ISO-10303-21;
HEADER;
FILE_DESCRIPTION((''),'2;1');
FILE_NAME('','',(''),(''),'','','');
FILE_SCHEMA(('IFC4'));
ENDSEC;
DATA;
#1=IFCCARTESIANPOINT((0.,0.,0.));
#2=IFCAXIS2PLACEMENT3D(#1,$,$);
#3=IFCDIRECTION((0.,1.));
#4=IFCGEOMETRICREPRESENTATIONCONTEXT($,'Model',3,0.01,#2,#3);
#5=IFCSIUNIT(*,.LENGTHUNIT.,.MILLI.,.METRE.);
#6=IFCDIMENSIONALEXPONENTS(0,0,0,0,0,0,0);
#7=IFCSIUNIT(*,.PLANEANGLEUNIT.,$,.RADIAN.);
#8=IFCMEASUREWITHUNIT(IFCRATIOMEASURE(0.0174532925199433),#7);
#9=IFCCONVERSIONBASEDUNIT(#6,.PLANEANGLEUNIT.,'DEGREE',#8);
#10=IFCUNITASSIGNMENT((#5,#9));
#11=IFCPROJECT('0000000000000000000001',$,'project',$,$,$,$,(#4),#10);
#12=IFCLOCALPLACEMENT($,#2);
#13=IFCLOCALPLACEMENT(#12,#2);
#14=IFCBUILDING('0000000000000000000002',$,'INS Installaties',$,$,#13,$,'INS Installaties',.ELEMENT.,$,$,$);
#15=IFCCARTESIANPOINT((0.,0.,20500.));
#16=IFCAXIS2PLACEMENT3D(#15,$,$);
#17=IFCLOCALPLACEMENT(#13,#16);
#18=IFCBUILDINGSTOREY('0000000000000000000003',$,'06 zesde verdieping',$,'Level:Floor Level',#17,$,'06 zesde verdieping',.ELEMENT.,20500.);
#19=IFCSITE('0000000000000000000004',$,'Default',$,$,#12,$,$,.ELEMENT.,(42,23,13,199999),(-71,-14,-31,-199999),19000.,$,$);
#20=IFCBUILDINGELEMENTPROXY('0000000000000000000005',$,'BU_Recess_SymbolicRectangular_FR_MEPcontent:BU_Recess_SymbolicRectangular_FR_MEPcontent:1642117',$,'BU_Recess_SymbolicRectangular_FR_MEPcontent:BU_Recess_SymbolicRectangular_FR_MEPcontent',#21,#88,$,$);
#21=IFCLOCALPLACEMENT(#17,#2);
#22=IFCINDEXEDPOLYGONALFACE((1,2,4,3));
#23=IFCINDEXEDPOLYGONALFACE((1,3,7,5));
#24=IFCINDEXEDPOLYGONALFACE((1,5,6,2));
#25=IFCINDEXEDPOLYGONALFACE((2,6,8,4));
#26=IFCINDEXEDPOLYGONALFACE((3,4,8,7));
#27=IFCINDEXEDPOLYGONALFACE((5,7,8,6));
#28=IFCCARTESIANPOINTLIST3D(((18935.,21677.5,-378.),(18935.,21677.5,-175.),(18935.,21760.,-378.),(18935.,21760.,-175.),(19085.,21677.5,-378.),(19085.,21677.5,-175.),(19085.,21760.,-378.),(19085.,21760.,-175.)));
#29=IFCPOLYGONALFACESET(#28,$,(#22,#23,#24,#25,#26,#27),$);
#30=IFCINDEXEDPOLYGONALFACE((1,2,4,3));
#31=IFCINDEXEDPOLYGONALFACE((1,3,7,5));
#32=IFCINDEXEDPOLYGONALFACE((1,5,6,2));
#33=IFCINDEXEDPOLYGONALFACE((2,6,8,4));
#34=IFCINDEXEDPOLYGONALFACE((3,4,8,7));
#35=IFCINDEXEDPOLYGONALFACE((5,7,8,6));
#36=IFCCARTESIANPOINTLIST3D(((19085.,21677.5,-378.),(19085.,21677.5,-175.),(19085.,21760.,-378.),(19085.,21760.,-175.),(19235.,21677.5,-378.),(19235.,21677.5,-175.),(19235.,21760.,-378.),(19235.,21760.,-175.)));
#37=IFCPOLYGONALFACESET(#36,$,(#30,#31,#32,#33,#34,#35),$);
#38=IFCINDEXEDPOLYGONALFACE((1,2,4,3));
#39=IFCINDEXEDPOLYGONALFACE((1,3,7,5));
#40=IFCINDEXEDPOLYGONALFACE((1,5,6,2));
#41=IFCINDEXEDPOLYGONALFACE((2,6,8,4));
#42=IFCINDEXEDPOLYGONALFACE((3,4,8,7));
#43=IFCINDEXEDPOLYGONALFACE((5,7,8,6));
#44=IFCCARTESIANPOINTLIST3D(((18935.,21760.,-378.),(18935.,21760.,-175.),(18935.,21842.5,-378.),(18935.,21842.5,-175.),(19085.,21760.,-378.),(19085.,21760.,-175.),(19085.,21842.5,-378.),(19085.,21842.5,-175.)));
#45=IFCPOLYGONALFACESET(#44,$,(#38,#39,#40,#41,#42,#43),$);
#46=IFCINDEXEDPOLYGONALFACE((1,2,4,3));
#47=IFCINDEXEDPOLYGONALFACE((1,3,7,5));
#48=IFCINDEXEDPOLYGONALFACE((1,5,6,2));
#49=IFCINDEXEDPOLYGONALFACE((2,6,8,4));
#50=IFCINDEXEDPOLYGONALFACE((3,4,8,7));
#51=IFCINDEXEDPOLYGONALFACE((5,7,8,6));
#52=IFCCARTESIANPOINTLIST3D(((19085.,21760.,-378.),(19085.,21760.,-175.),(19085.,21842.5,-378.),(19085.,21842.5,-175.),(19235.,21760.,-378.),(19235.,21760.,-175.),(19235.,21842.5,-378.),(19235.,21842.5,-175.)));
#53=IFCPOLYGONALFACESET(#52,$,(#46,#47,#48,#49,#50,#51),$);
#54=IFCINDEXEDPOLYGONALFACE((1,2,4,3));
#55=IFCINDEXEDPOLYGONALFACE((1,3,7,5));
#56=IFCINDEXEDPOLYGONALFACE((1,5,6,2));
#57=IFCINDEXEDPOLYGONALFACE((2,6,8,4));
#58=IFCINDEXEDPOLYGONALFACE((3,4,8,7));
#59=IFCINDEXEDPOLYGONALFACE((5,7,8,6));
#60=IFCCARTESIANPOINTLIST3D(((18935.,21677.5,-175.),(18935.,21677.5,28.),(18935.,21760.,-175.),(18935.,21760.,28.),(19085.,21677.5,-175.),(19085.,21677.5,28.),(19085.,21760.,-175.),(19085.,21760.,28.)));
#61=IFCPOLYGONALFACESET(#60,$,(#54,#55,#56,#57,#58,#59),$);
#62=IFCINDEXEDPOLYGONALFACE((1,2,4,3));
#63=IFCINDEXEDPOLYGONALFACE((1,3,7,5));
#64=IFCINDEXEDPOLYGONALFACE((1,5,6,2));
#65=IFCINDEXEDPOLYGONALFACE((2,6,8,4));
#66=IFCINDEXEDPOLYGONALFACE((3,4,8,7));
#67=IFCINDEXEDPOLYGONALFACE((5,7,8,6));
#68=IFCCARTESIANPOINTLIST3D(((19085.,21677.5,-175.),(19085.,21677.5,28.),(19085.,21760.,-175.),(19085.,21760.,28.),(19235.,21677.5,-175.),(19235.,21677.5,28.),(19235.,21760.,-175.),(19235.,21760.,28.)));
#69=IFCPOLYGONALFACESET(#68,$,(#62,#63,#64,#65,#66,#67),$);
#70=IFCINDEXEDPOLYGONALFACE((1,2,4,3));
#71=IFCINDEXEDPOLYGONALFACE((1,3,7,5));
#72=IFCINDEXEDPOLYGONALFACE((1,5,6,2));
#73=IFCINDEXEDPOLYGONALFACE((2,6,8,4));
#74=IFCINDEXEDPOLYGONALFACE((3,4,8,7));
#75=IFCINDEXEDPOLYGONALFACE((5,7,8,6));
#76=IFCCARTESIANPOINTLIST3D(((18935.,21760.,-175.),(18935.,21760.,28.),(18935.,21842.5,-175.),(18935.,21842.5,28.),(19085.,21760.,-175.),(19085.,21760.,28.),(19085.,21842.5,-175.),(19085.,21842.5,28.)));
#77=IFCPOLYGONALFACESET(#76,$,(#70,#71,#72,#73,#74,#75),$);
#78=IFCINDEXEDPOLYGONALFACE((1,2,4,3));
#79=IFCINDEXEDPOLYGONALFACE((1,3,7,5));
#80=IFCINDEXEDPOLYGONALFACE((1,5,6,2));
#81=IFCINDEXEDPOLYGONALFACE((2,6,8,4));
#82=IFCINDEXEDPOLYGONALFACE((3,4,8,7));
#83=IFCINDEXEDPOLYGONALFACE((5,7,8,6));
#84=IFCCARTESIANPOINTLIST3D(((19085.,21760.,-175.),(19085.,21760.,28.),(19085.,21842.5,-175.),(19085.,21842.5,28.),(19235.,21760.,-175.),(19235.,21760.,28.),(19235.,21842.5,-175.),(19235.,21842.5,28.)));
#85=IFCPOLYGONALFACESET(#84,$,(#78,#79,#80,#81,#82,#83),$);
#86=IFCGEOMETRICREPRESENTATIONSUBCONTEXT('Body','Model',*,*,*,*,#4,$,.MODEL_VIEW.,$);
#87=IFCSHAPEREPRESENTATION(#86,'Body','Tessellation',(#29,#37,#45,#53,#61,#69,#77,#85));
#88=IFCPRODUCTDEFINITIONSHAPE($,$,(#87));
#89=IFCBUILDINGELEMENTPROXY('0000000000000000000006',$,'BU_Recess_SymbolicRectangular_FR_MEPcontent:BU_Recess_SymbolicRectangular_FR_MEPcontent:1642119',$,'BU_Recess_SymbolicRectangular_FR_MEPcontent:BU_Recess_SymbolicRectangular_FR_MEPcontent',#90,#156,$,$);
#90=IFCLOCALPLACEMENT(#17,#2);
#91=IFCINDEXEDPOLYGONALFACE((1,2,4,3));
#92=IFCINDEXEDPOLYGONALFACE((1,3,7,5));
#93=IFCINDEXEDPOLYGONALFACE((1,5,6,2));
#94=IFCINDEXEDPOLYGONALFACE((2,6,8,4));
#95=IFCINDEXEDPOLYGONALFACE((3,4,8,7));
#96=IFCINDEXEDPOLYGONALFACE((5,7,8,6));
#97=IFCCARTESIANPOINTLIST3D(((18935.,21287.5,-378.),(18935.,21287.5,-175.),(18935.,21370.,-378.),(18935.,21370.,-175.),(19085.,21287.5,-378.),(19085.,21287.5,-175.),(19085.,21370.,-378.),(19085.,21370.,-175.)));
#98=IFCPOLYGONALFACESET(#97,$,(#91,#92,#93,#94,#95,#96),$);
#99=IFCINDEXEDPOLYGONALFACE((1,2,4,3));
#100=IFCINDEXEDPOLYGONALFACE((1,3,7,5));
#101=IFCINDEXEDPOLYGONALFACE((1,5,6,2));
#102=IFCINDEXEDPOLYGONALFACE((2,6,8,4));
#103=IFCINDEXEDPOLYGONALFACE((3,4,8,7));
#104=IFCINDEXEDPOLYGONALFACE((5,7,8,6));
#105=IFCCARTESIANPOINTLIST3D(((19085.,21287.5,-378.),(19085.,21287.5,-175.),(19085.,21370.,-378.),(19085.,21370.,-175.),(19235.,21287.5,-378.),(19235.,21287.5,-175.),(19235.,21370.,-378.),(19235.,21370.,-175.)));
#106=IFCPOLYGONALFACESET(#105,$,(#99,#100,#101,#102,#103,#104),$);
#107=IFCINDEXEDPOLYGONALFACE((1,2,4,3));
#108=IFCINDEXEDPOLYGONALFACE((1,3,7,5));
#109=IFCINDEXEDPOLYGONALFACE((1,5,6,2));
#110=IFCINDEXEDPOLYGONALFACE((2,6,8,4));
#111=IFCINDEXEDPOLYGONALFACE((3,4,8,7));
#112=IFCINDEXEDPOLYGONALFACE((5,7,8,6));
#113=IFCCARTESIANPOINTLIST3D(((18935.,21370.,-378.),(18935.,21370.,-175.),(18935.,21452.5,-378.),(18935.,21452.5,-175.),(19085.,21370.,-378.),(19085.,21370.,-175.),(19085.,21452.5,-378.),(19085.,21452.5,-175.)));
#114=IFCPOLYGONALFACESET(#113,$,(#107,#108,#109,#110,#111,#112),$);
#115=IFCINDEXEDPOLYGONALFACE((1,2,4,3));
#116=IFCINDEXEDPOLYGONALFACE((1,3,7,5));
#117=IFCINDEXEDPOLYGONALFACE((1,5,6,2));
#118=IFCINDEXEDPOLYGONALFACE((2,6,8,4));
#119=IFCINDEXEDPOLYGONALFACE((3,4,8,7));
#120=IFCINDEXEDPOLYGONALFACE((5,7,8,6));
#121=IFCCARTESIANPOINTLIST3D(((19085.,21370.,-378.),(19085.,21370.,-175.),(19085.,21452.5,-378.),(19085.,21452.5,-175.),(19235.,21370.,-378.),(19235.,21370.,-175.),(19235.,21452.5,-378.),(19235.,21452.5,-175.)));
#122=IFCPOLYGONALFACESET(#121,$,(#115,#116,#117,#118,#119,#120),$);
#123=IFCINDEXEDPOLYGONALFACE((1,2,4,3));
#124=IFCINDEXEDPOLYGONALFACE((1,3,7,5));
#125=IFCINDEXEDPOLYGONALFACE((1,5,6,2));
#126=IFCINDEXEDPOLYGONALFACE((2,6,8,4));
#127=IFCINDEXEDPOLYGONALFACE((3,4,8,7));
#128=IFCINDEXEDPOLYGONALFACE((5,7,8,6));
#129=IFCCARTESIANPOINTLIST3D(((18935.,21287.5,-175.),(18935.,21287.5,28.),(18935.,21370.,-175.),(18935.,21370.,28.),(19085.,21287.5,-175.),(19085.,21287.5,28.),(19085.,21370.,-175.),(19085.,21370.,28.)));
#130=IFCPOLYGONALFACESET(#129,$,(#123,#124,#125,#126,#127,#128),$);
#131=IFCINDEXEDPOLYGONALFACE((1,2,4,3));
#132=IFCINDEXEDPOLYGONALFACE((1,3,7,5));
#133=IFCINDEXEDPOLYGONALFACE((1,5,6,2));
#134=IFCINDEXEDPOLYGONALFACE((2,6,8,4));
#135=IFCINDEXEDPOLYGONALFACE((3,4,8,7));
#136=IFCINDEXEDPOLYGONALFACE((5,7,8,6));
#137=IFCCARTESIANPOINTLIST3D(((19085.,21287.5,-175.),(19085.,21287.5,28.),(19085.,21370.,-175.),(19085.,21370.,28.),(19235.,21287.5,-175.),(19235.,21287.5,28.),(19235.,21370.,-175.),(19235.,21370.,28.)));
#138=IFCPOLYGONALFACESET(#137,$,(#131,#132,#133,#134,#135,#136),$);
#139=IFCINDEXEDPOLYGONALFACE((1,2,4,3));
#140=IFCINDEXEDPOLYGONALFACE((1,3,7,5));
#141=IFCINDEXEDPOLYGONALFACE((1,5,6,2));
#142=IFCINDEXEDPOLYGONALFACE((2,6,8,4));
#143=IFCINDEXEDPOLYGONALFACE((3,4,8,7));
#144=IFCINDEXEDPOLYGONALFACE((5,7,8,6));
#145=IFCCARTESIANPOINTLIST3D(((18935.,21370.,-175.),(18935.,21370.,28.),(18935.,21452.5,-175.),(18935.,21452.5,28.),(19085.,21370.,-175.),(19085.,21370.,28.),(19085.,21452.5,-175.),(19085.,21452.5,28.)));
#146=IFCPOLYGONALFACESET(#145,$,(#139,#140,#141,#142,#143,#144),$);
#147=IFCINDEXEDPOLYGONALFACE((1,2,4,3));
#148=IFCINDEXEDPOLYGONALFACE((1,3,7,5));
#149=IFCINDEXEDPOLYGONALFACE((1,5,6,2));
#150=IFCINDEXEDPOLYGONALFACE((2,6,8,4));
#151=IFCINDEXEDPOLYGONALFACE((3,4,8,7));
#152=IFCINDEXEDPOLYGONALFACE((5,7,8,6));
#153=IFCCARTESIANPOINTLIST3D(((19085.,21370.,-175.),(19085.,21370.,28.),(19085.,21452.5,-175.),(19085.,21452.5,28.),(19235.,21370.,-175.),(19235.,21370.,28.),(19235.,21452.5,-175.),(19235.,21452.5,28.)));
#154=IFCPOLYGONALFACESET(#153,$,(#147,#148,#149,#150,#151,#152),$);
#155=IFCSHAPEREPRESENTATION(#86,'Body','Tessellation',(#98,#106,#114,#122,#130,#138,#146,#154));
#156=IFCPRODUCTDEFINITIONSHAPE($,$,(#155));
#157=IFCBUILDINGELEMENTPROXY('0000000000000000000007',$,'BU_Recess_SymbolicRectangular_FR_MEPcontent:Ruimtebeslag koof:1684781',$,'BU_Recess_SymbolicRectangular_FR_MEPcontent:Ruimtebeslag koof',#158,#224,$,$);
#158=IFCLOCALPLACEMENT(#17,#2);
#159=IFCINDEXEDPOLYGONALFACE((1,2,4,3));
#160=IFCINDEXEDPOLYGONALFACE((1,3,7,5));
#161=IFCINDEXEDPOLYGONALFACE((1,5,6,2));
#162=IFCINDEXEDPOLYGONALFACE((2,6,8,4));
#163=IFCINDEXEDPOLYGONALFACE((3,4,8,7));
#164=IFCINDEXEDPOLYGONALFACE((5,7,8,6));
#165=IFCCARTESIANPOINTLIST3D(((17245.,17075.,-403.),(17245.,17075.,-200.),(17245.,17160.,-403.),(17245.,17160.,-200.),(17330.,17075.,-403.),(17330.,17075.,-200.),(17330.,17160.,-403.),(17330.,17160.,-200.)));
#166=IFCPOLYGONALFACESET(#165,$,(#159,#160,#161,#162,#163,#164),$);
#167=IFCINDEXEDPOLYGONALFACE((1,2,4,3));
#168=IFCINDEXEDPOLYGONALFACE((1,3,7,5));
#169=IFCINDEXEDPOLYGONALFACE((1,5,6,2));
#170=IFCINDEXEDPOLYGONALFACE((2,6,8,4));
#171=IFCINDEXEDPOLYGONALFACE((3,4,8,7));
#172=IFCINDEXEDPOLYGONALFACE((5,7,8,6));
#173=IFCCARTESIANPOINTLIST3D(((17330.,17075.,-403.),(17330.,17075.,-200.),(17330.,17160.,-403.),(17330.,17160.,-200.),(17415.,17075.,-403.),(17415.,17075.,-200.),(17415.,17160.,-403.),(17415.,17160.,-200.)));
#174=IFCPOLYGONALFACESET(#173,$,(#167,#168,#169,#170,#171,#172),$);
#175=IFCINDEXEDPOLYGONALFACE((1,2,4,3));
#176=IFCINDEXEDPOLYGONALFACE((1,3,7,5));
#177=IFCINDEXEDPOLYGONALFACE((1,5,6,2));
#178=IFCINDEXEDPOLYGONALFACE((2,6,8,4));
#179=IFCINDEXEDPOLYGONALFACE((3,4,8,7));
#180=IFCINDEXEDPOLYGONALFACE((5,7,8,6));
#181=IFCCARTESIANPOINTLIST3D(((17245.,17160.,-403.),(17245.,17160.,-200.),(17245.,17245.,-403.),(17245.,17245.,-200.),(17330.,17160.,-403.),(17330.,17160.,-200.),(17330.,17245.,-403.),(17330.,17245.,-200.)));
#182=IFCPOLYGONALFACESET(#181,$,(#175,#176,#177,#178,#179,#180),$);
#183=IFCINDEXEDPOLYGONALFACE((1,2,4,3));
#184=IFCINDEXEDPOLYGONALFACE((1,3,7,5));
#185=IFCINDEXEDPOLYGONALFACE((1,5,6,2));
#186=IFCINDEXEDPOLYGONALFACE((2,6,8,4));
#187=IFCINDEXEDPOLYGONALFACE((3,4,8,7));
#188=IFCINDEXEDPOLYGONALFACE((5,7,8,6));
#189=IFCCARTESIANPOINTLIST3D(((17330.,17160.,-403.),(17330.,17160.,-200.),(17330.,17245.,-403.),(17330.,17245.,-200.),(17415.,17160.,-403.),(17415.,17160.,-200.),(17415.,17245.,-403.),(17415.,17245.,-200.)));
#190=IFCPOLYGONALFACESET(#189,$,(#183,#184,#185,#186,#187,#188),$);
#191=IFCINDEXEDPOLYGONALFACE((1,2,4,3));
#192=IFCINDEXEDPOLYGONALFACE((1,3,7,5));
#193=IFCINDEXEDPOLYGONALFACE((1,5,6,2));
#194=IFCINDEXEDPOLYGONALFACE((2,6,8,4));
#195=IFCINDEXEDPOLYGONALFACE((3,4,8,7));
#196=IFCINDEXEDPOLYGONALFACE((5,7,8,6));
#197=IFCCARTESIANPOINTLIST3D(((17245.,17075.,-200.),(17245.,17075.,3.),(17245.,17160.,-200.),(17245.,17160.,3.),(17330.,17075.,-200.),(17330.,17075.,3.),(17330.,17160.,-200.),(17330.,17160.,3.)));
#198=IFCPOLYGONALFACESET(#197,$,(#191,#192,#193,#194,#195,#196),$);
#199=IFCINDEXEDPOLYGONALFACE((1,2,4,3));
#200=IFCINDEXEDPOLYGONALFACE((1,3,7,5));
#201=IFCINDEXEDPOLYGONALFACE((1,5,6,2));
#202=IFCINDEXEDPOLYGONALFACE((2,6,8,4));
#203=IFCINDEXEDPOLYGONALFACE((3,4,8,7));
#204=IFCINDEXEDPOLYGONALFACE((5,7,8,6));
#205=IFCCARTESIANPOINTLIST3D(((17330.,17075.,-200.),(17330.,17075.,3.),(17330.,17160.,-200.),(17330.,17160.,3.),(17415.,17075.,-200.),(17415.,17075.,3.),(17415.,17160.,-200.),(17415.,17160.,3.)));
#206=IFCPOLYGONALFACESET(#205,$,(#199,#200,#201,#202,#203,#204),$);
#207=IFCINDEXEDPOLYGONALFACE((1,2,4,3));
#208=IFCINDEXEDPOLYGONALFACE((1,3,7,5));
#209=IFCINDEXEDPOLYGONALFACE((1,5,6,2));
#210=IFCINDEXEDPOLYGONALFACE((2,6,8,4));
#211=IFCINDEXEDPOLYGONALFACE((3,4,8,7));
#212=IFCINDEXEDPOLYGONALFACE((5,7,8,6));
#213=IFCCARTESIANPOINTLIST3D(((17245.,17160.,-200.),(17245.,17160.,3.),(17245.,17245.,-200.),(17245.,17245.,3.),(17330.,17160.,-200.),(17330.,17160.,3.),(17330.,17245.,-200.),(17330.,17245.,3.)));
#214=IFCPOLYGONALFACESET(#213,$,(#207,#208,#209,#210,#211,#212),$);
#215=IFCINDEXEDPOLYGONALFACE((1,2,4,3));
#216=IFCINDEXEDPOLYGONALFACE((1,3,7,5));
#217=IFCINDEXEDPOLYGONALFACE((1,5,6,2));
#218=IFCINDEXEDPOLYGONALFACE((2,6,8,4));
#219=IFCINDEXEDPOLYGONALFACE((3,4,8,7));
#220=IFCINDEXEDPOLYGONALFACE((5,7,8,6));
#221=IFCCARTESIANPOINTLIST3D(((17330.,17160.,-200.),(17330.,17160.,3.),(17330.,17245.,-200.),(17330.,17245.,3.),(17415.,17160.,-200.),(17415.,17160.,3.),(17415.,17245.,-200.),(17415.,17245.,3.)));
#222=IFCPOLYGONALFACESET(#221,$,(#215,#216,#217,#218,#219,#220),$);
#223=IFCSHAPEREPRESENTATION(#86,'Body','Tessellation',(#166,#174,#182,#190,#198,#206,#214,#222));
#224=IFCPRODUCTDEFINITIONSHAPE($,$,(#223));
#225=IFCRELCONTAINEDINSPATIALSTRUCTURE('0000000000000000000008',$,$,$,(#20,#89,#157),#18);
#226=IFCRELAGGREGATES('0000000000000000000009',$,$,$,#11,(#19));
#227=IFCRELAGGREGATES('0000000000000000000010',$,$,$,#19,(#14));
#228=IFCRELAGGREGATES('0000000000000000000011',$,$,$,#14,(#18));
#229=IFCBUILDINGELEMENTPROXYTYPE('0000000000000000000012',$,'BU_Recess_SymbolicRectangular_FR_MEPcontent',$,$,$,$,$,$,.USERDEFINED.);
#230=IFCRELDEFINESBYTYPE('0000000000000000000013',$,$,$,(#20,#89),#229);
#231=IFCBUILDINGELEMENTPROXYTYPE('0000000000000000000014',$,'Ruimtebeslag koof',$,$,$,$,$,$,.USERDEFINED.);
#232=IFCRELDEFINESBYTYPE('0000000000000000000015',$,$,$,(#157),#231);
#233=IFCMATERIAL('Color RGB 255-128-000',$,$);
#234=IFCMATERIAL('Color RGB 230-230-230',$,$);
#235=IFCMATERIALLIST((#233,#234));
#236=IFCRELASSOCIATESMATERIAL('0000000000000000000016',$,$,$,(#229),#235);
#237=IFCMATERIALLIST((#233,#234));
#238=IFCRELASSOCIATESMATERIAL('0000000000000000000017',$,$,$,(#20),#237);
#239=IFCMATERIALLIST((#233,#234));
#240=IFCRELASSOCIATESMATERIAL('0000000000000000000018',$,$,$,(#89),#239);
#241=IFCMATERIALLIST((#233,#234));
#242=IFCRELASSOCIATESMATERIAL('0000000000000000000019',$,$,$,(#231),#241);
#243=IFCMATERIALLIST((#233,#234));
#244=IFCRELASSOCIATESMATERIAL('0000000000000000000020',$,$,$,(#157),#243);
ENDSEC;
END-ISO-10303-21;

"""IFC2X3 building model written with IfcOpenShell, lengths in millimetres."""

from ifc_helpers import new_model, entity, si_unit, converted_unit, direction, frame, frame_2d, origin, origin_2d_with_axis, place, context, subcontext, project, spatial, rectangle, extrude, source, transform, mapped, material, material_list, type_object, type_shapes, element, save


model = new_model("IFC2X3")

# Units and contexts
model_context = context("Model", 3, precision=0.01, world=origin(), true_north=direction((0.0, 1.0)))
body_context = subcontext(model_context, "Body", "Model", "MODEL_VIEW")
ifc_project = project(units=[si_unit("LENGTHUNIT", "METRE", prefix="MILLI"), converted_unit("PLANEANGLEUNIT", "DEGREE", entity("IfcRatioMeasure", 0.0174532925199433), si_unit("PLANEANGLEUNIT", "RADIAN"), dimensions=[0, 0, 0, 0, 0, 0, 0])], contexts=[model_context])

# Site, building, storey
site_placement = place(None, origin())
site = spatial("IfcSite", under=ifc_project, at=site_placement, Name="Default", CompositionType="ELEMENT", RefLatitude=(42, 23, 13, 199999), RefLongitude=(-71, -14, -31, -199999), RefElevation=19000.0)
building_placement = place(site_placement, origin())
building = spatial("IfcBuilding", under=site, at=building_placement, Name="INS Installaties", LongName="INS Installaties", CompositionType="ELEMENT")
storey_placement = place(building_placement, frame((0.0, 0.0, 20500.0)))
storey = spatial("IfcBuildingStorey", under=building, at=storey_placement, Name="06 zesde verdieping", ObjectType="Level:Floor Level", LongName="06 zesde verdieping", CompositionType="ELEMENT", Elevation=20500.0)

# Building element proxies
ifc_material_1 = material(Name="Color RGB 255-128-000")
ifc_material_2 = material(Name="Color RGB 230-230-230")
ifc_material_list_1 = material_list([ifc_material_1, ifc_material_2])
ifc_material_list_2 = material_list([ifc_material_1, ifc_material_2])
building_element_proxy_type_1 = type_object("IfcBuildingElementProxyType", Name="BU_Recess_SymbolicRectangular_FR_MEPcontent", PredefinedType="USERDEFINED", material=ifc_material_list_2)
shared_shape_1 = source(origin(), body_context, "Body", "SweptSolid", [
    extrude(rectangle(XDim=82.5, YDim=150.0, at=origin_2d_with_axis()), frame((75.0, 41.2, -403.0), z_axis=(0.0, 0.0, 1.0), x_axis=(0.0, -1.0, 0.0)), (0.0, 0.0, 1.0), 203.0),
    extrude(rectangle(XDim=150.0, YDim=82.5, at=frame_2d((0.0, 0.0), x_axis=(1.0, 0.0))), frame((-75.0, 41.2, -403.0), z_axis=(0.0, 0.0, 1.0), x_axis=(-1.0, 0.0, 0.0)), (0.0, 0.0, 1.0), 203.0),
    extrude(rectangle(XDim=150.0, YDim=82.5, at=frame_2d((0.0, 0.0), x_axis=(1.0, 0.0))), frame((75.0, -41.3, -403.0)), (0.0, 0.0, 1.0), 203.0),
    extrude(rectangle(XDim=82.5, YDim=150.0, at=origin_2d_with_axis()), frame((-75.0, -41.3, -403.0), z_axis=(0.0, 0.0, 1.0), x_axis=(0.0, 1.0, 0.0)), (0.0, 0.0, 1.0), 203.0),
    extrude(rectangle(XDim=82.5, YDim=150.0, at=origin_2d_with_axis()), frame((75.0, 41.3, -200.0), z_axis=(0.0, 0.0, 1.0), x_axis=(0.0, -1.0, 0.0)), (0.0, 0.0, 1.0), 203.0),
    extrude(rectangle(XDim=150.0, YDim=82.5, at=frame_2d((0.0, 0.0), x_axis=(1.0, 0.0))), frame((-75.0, 41.3, -200.0), z_axis=(0.0, 0.0, 1.0), x_axis=(-1.0, 0.0, 0.0)), (0.0, 0.0, 1.0), 203.0),
    extrude(rectangle(XDim=150.0, YDim=82.5, at=frame_2d((0.0, 0.0), x_axis=(1.0, 0.0))), frame((75.0, -41.2, -200.0)), (0.0, 0.0, 1.0), 203.0),
    extrude(rectangle(XDim=82.5, YDim=150.0, at=origin_2d_with_axis()), frame((-75.0, -41.2, -200.0), z_axis=(0.0, 0.0, 1.0), x_axis=(0.0, 1.0, 0.0)), (0.0, 0.0, 1.0), 203.0),
])
type_shapes(building_element_proxy_type_1, [shared_shape_1])
proxy_1_placement = place(storey_placement, frame((19085.0, 21760.0, 25.0), z_axis=(0.0, 0.0, 1.0), x_axis=(-1.0, 0.0, 0.0)))
element("IfcBuildingElementProxy", 1, at=proxy_1_placement, inside=storey, type_object=building_element_proxy_type_1, material=ifc_material_list_1, Name="BU_Recess_SymbolicRectangular_FR_MEPcontent:BU_Recess_SymbolicRectangular_FR_MEPcontent:1642117", ObjectType="BU_Recess_SymbolicRectangular_FR_MEPcontent:BU_Recess_SymbolicRectangular_FR_MEPcontent", context=body_context, shape_type="MappedRepresentation", body=[
    mapped(shared_shape_1, transform((0.0, 0.0, 0.0), scale=1.0)),
])
ifc_material_list_3 = material_list([ifc_material_1, ifc_material_2])
proxy_2_placement = place(storey_placement, frame((19085.0, 21370.0, 25.0), z_axis=(0.0, 0.0, 1.0), x_axis=(-1.0, 0.0, 0.0)))
element("IfcBuildingElementProxy", 2, at=proxy_2_placement, inside=storey, type_object=building_element_proxy_type_1, material=ifc_material_list_3, Name="BU_Recess_SymbolicRectangular_FR_MEPcontent:BU_Recess_SymbolicRectangular_FR_MEPcontent:1642119", ObjectType="BU_Recess_SymbolicRectangular_FR_MEPcontent:BU_Recess_SymbolicRectangular_FR_MEPcontent", context=body_context, shape_type="MappedRepresentation", body=[
    mapped(shared_shape_1, transform((0.0, 0.0, 0.0), scale=1.0)),
])
ifc_material_list_4 = material_list([ifc_material_1, ifc_material_2])
ifc_material_list_5 = material_list([ifc_material_1, ifc_material_2])
building_element_proxy_type_2 = type_object("IfcBuildingElementProxyType", Name="Ruimtebeslag koof", PredefinedType="USERDEFINED", material=ifc_material_list_5)
shared_shape_2 = source(origin(), body_context, "Body", "SweptSolid", [
    extrude(rectangle(XDim=85.0, YDim=85.0, at=origin_2d_with_axis()), frame((42.5, 42.5, -403.0), z_axis=(0.0, 0.0, 1.0), x_axis=(0.0, -1.0, 0.0)), (0.0, 0.0, 1.0), 203.0),
    extrude(rectangle(XDim=85.0, YDim=85.0, at=origin_2d_with_axis()), frame((-42.5, 42.5, -403.0), z_axis=(0.0, 0.0, 1.0), x_axis=(-1.0, 0.0, 0.0)), (0.0, 0.0, 1.0), 203.0),
    extrude(rectangle(XDim=85.0, YDim=85.0, at=frame_2d((0.0, 0.0), x_axis=(1.0, 0.0))), frame((42.5, -42.5, -403.0)), (0.0, 0.0, 1.0), 203.0),
    extrude(rectangle(XDim=85.0, YDim=85.0, at=origin_2d_with_axis()), frame((-42.5, -42.5, -403.0), z_axis=(0.0, 0.0, 1.0), x_axis=(0.0, 1.0, 0.0)), (0.0, 0.0, 1.0), 203.0),
    extrude(rectangle(XDim=85.0, YDim=85.0, at=origin_2d_with_axis()), frame((42.5, 42.5, -200.0), z_axis=(0.0, 0.0, 1.0), x_axis=(0.0, -1.0, 0.0)), (0.0, 0.0, 1.0), 203.0),
    extrude(rectangle(XDim=85.0, YDim=85.0, at=frame_2d((0.0, 0.0), x_axis=(1.0, 0.0))), frame((-42.5, 42.5, -200.0), z_axis=(0.0, 0.0, 1.0), x_axis=(-1.0, 0.0, 0.0)), (0.0, 0.0, 1.0), 203.0),
    extrude(rectangle(XDim=85.0, YDim=85.0, at=frame_2d((0.0, 0.0), x_axis=(1.0, 0.0))), frame((42.5, -42.5, -200.0)), (0.0, 0.0, 1.0), 203.0),
    extrude(rectangle(XDim=85.0, YDim=85.0, at=origin_2d_with_axis()), frame((-42.5, -42.5, -200.0), z_axis=(0.0, 0.0, 1.0), x_axis=(0.0, 1.0, 0.0)), (0.0, 0.0, 1.0), 203.0),
])
type_shapes(building_element_proxy_type_2, [shared_shape_2])
proxy_3_placement = place(storey_placement, frame((17330.0, 17160.0, 0.0), z_axis=(0.0, 0.0, 1.0), x_axis=(-1.0, 0.0, 0.0)))
element("IfcBuildingElementProxy", 3, at=proxy_3_placement, inside=storey, type_object=building_element_proxy_type_2, material=ifc_material_list_4, Name="BU_Recess_SymbolicRectangular_FR_MEPcontent:Ruimtebeslag koof:1684781", ObjectType="BU_Recess_SymbolicRectangular_FR_MEPcontent:Ruimtebeslag koof", context=body_context, shape_type="MappedRepresentation", body=[
    mapped(shared_shape_2, transform((0.0, 0.0, 0.0), scale=1.0)),
])

save(model, "model.ifc")
